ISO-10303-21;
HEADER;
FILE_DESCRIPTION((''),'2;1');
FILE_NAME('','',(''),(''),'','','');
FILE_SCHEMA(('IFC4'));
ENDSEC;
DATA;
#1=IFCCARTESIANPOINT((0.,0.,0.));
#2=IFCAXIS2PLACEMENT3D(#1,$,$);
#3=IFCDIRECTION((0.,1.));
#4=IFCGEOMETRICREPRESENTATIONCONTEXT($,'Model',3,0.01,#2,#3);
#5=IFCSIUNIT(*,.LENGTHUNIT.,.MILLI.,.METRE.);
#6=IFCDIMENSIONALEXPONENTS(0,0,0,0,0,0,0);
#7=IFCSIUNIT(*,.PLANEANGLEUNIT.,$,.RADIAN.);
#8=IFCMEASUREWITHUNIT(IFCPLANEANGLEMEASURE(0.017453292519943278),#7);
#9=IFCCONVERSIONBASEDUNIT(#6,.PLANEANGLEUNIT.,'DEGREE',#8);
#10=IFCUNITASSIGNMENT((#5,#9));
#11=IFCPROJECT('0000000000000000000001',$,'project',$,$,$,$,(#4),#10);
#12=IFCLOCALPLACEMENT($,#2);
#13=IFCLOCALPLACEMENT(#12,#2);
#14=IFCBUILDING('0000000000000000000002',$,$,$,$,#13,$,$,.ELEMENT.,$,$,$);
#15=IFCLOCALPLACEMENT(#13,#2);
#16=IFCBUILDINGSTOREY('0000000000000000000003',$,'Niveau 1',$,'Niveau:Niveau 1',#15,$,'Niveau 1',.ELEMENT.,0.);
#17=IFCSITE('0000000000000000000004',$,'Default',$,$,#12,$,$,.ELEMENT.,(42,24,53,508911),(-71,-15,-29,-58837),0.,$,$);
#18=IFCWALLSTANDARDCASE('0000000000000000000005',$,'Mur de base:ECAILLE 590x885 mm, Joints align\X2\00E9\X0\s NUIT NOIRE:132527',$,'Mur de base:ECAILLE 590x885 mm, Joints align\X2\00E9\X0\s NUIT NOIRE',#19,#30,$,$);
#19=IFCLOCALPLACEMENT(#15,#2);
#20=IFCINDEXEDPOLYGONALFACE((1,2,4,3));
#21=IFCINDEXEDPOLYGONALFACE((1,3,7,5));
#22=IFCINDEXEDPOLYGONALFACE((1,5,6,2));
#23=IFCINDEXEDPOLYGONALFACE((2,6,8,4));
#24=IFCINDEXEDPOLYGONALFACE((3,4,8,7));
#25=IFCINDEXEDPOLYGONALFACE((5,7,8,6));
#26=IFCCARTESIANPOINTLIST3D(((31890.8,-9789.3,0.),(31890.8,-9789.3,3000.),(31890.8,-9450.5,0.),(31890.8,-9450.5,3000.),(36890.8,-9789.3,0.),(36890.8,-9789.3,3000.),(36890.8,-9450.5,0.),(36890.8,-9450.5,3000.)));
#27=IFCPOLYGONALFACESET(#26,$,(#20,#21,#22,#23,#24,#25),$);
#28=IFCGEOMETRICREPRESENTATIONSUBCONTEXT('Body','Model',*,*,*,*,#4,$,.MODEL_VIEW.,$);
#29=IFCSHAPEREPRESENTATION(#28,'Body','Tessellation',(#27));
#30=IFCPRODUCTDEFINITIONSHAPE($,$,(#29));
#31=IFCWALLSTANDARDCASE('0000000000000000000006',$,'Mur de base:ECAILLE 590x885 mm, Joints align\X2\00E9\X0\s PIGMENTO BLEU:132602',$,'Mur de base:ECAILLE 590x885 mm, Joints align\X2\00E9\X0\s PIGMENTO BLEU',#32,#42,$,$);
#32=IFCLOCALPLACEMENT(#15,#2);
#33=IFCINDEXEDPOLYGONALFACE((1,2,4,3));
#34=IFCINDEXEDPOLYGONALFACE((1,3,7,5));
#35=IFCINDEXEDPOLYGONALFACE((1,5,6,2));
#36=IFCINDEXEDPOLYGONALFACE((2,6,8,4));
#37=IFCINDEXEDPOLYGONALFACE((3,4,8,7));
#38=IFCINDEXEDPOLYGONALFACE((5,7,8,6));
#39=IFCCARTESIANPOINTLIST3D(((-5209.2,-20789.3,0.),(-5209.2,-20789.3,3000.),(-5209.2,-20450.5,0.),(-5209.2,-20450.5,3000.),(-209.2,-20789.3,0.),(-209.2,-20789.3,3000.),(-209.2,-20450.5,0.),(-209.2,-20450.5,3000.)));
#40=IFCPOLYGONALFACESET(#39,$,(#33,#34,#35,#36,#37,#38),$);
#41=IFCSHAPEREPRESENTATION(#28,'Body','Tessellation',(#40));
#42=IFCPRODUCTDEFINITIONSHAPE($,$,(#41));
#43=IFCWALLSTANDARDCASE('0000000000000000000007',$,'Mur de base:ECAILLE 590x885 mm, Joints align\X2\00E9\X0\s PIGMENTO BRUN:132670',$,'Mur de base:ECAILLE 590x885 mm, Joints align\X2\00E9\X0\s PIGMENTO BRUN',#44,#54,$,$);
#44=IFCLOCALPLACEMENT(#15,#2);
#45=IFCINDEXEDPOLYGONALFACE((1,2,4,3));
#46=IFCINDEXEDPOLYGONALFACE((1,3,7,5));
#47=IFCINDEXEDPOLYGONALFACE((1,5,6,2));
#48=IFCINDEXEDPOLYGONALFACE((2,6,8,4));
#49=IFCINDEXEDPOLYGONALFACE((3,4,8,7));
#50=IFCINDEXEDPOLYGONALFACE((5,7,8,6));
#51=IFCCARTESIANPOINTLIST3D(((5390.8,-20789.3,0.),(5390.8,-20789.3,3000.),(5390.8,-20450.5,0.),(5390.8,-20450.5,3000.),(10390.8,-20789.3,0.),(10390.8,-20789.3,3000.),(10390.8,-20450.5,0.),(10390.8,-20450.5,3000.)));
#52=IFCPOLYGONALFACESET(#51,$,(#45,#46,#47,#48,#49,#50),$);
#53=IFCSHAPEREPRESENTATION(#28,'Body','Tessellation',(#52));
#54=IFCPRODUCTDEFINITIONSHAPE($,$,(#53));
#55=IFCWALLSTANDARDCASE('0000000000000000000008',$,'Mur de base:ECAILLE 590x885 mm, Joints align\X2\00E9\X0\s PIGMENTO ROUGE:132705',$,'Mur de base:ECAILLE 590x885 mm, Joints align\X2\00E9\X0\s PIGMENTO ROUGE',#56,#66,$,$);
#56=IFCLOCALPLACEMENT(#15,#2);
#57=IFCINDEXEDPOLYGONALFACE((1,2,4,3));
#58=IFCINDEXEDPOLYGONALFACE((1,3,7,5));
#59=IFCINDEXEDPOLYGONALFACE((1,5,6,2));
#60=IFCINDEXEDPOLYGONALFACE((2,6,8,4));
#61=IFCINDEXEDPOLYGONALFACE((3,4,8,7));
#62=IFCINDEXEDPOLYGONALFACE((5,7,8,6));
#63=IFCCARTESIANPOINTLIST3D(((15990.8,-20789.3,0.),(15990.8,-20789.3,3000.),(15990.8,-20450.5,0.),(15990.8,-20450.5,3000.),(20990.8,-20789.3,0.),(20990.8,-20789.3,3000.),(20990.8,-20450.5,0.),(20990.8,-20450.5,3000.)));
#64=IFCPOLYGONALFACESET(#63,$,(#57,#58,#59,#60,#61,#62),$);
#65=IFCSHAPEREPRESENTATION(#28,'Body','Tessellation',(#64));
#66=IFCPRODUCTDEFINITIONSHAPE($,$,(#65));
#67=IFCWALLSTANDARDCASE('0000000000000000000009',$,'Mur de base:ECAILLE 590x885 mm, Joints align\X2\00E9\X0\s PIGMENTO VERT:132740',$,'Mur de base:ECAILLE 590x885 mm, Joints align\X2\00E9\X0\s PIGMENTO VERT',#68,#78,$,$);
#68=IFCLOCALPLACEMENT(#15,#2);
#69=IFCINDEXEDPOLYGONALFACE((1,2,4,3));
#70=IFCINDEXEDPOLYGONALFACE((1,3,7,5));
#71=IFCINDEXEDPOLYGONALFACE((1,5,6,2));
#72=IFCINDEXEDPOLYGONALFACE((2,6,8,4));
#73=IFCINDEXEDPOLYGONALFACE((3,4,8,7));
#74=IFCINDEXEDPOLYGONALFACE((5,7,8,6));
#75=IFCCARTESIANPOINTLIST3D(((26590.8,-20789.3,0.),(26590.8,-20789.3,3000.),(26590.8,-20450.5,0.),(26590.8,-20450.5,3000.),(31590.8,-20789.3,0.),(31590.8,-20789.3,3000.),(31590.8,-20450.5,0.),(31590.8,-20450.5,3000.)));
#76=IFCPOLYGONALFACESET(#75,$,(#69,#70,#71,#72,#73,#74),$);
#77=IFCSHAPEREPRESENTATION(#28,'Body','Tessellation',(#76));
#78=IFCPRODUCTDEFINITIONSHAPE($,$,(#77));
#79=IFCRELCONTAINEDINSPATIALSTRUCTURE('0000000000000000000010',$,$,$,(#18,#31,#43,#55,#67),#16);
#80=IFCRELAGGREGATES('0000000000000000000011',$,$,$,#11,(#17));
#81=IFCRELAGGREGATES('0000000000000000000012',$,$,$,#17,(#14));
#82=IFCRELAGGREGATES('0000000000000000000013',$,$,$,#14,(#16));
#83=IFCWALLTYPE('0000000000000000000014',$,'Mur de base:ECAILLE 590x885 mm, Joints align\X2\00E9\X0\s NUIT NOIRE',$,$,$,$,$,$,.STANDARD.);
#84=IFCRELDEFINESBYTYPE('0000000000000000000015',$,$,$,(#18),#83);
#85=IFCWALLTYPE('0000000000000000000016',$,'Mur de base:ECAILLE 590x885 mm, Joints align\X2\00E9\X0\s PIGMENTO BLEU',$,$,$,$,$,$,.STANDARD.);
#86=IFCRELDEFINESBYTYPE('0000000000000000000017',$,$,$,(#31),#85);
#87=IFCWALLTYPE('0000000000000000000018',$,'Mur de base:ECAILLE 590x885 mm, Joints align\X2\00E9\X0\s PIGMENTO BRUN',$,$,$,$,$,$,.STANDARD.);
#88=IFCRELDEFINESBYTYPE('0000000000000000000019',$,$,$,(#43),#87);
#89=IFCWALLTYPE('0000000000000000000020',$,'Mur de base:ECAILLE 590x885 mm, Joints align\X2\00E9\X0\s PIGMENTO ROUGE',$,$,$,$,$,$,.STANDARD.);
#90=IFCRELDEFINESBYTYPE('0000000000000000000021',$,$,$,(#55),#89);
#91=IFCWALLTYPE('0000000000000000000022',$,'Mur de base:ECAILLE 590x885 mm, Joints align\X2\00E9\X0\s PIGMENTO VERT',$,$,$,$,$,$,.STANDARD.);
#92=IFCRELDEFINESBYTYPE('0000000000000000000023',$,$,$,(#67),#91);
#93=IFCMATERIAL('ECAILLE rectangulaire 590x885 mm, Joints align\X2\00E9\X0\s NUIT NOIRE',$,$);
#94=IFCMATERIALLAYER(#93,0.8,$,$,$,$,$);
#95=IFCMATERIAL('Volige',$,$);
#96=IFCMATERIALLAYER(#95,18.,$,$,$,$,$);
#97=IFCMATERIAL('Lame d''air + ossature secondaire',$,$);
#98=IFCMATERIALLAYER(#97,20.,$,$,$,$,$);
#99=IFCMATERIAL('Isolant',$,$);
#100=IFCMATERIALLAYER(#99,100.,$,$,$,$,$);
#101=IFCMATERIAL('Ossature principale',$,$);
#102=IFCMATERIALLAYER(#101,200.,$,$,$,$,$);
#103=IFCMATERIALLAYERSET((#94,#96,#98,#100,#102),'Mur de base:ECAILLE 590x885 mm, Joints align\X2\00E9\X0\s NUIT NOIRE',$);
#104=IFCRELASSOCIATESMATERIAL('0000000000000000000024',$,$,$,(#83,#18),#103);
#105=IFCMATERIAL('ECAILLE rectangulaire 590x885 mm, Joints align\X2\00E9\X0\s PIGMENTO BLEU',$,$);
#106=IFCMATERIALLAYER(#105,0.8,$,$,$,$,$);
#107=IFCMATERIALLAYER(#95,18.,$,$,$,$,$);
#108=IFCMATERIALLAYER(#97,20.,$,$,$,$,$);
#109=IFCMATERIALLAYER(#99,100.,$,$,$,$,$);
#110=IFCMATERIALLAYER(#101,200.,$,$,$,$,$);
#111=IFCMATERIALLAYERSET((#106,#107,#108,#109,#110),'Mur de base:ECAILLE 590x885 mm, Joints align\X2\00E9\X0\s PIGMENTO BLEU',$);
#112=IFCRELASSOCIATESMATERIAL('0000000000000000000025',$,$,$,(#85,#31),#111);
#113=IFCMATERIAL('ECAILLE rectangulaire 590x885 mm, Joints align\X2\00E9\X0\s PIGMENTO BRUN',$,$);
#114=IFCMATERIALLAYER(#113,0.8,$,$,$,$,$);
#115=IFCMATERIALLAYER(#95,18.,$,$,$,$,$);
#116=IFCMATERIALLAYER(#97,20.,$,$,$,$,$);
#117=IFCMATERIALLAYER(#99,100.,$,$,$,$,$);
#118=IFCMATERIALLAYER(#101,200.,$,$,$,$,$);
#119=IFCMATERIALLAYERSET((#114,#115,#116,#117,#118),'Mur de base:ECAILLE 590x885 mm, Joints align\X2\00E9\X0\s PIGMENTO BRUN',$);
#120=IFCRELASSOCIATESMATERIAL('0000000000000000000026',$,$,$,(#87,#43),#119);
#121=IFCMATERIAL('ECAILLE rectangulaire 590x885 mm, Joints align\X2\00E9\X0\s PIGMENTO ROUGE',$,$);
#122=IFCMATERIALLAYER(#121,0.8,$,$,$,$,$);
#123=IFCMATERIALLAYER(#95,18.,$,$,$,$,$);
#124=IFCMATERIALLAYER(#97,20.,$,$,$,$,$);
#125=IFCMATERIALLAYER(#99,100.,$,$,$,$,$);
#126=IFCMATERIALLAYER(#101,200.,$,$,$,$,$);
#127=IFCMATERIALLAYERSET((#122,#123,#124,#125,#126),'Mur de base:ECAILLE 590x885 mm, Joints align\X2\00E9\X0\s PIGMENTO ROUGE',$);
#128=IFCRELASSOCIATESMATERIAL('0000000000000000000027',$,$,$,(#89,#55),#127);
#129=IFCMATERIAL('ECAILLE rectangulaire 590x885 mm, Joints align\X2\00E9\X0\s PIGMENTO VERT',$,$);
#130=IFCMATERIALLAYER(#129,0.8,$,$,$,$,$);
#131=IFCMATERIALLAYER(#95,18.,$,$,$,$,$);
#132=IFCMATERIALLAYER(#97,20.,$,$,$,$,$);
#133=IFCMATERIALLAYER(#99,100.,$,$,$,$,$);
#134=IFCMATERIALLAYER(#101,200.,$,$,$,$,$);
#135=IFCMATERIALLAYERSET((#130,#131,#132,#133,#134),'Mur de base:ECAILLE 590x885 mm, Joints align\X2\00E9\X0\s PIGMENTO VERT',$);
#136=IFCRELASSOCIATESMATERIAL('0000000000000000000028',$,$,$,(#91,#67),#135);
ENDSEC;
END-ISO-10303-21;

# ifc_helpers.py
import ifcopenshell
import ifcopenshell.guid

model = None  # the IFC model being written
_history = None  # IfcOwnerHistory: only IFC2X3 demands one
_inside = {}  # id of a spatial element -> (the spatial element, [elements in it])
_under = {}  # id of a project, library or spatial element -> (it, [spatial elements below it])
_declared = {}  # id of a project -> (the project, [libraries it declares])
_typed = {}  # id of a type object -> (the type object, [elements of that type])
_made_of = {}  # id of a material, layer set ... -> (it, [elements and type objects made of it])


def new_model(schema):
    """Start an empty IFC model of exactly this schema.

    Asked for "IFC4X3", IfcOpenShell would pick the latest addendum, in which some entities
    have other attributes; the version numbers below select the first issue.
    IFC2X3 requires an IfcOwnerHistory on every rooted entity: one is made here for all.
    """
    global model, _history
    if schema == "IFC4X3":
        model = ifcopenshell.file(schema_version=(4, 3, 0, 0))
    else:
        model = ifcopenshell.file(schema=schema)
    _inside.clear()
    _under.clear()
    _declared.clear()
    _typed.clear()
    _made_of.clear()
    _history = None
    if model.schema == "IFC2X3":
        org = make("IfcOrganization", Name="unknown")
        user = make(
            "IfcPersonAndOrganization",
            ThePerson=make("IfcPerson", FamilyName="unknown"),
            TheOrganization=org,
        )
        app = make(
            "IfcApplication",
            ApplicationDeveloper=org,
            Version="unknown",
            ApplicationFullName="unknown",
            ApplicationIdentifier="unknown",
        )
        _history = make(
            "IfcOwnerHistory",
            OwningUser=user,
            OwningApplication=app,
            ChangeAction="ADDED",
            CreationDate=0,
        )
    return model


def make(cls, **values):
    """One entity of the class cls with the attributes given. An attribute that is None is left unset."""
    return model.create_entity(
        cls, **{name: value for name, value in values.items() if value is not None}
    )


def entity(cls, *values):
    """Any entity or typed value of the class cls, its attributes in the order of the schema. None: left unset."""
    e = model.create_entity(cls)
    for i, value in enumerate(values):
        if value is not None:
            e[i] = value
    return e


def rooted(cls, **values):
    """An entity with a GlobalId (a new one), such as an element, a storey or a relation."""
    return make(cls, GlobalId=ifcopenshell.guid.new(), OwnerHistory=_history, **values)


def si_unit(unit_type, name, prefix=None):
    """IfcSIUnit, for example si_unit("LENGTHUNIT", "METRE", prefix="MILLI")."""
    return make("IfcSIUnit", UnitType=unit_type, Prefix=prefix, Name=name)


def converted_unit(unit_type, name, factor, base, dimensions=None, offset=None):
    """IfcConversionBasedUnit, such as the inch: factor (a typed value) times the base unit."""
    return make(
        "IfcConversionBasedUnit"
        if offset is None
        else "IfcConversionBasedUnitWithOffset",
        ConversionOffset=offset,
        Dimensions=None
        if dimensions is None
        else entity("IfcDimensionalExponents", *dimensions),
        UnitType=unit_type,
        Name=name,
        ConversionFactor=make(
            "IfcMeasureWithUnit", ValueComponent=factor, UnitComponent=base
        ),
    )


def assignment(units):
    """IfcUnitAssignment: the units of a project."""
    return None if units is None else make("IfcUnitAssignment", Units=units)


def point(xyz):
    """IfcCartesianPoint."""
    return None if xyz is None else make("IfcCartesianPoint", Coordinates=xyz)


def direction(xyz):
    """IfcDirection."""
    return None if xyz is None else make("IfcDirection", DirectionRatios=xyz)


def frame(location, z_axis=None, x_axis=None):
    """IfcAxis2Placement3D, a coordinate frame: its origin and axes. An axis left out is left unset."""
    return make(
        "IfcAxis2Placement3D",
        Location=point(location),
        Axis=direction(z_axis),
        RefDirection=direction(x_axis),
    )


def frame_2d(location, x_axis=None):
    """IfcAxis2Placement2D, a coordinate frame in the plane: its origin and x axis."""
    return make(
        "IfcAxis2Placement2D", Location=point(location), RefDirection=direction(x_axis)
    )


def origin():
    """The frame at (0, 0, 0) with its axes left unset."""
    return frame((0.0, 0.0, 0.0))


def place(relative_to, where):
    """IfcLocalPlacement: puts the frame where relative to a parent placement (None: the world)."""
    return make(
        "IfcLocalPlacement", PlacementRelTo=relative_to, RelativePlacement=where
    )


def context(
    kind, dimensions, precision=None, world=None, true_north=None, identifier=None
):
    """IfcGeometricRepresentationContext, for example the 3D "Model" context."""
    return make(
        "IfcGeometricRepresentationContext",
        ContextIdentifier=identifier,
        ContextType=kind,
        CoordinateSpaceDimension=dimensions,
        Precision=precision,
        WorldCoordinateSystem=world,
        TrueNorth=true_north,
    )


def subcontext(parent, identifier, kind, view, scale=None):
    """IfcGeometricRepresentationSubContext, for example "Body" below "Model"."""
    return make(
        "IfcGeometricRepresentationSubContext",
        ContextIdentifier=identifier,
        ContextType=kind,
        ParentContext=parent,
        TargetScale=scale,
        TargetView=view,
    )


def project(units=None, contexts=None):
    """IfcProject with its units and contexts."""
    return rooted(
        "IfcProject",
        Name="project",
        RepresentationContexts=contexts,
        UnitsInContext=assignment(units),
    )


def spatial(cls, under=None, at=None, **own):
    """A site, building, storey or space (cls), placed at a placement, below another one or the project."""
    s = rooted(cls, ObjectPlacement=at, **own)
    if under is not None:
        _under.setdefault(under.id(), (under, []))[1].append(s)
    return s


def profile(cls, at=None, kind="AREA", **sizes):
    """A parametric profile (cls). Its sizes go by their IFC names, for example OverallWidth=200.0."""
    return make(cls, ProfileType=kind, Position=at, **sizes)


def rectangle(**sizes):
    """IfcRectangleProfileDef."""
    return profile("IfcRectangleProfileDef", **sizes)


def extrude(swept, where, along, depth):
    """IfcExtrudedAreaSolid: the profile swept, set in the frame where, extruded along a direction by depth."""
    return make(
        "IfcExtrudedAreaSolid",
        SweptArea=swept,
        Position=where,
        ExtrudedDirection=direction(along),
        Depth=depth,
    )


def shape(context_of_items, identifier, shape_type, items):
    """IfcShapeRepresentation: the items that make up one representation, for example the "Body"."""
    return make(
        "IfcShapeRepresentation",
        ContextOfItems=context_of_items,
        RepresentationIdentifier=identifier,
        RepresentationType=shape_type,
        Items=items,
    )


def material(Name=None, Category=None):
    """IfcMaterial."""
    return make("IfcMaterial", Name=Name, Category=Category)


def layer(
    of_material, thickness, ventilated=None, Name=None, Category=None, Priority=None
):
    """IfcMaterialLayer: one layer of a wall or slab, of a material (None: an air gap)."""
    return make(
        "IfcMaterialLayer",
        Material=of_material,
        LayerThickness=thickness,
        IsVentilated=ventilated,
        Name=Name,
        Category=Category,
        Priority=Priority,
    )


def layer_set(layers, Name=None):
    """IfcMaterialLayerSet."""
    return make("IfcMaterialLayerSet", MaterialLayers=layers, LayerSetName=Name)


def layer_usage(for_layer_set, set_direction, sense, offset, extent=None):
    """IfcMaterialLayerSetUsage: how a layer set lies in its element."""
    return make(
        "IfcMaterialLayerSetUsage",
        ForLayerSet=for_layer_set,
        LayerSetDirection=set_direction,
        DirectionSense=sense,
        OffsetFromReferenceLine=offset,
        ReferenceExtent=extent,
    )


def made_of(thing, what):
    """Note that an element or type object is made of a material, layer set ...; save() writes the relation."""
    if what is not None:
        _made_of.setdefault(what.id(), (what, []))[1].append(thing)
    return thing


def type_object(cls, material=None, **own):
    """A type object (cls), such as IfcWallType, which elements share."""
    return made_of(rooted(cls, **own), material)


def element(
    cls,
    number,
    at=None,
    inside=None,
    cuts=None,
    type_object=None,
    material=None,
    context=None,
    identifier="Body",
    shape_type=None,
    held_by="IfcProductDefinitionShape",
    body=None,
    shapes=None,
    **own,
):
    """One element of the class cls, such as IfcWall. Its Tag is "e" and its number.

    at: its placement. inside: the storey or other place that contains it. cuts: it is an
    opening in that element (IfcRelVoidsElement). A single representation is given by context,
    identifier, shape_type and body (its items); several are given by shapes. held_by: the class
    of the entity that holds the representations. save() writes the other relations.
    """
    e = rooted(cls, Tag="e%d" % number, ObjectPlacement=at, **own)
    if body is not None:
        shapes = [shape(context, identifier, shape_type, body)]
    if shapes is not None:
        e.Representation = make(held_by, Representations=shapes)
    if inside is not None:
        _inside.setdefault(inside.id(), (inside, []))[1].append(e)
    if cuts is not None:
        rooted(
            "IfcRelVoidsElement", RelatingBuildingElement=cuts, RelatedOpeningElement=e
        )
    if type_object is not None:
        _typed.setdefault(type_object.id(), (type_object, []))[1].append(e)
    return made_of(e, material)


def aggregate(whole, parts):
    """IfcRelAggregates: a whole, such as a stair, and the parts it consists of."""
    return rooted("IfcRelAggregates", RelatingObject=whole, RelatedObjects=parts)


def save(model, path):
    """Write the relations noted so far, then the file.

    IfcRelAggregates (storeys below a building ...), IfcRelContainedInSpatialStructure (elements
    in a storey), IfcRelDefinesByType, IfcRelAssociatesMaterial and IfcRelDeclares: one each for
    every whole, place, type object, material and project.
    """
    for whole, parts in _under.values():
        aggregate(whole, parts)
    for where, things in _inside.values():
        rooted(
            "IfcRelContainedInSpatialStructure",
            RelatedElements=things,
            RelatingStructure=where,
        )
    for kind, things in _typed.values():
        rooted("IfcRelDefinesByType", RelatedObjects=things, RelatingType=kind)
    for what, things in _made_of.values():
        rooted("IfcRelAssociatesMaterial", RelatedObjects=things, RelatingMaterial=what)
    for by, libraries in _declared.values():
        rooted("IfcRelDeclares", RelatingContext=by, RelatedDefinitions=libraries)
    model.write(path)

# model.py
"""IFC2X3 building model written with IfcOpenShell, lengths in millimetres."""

from ifc_helpers import new_model, entity, si_unit, converted_unit, direction, frame, frame_2d, origin, place, context, subcontext, project, spatial, rectangle, extrude, material, layer, layer_set, layer_usage, type_object, element, save


model = new_model("IFC2X3")

# Units and contexts
model_context = context("Model", 3, precision=0.01, world=origin(), true_north=direction((0.0, 1.0)))
body_context = subcontext(model_context, "Body", "Model", "MODEL_VIEW")
ifc_project = project(units=[si_unit("LENGTHUNIT", "METRE", prefix="MILLI"), converted_unit("PLANEANGLEUNIT", "DEGREE", entity("IfcPlaneAngleMeasure", 0.017453292519943278), si_unit("PLANEANGLEUNIT", "RADIAN"), dimensions=[0, 0, 0, 0, 0, 0, 0])], contexts=[model_context])

# Site, building, storey
site_placement = place(None, origin())
site = spatial("IfcSite", under=ifc_project, at=site_placement, Name="Default", CompositionType="ELEMENT", RefLatitude=(42, 24, 53, 508911), RefLongitude=(-71, -15, -29, -58837), RefElevation=0.0)
building_placement = place(site_placement, origin())
building = spatial("IfcBuilding", under=site, at=building_placement, CompositionType="ELEMENT")
storey_placement = place(building_placement, origin())
storey = spatial("IfcBuildingStorey", under=building, at=storey_placement, Name="Niveau 1", ObjectType="Niveau:Niveau 1", LongName="Niveau 1", CompositionType="ELEMENT", Elevation=0.0)

# Walls
ifc_material_1 = material(Name="Volige")
ifc_material_2 = material(Name="Lame d'air + ossature secondaire")
ifc_material_3 = material(Name="Isolant")
ifc_material_4 = material(Name="Ossature principale")
ifc_material_5 = material(Name="ECAILLE rectangulaire 590x885 mm, Joints alignés NUIT NOIRE")
ifc_layer_1 = layer(ifc_material_5, 0.8)
ifc_layer_2 = layer(ifc_material_1, 18.0)
ifc_layer_3 = layer(ifc_material_2, 20.0)
ifc_layer_4 = layer(ifc_material_3, 100.0)
ifc_layer_5 = layer(ifc_material_4, 200.0)
ifc_layer_set_1 = layer_set([ifc_layer_1, ifc_layer_2, ifc_layer_3, ifc_layer_4, ifc_layer_5], Name="Mur de base:ECAILLE 590x885 mm, Joints alignés NUIT NOIRE")
ifc_layer_usage_1 = layer_usage(ifc_layer_set_1, "AXIS2", "NEGATIVE", 169.4)
wall_type_1 = type_object("IfcWallType", Name="Mur de base:ECAILLE 590x885 mm, Joints alignés NUIT NOIRE", PredefinedType="STANDARD", material=ifc_layer_set_1)
wall_1_placement = place(storey_placement, frame((36890.8, -9619.9, 0.0), z_axis=(0.0, 0.0, 1.0), x_axis=(-1.0, 0.0, 0.0)))
element("IfcWallStandardCase", 1, at=wall_1_placement, inside=storey, type_object=wall_type_1, material=ifc_layer_usage_1, Name="Mur de base:ECAILLE 590x885 mm, Joints alignés NUIT NOIRE:132527", ObjectType="Mur de base:ECAILLE 590x885 mm, Joints alignés NUIT NOIRE", context=body_context, shape_type="SweptSolid", body=[
    extrude(rectangle(XDim=5000.0, YDim=338.8, at=frame_2d((2500.0, 0.0), x_axis=(-1.0, 0.0))), origin(), (0.0, 0.0, 1.0), 3000.0),
])
ifc_material_6 = material(Name="ECAILLE rectangulaire 590x885 mm, Joints alignés PIGMENTO BLEU")
ifc_layer_6 = layer(ifc_material_6, 0.8)
ifc_layer_7 = layer(ifc_material_1, 18.0)
ifc_layer_8 = layer(ifc_material_2, 20.0)
ifc_layer_9 = layer(ifc_material_3, 100.0)
ifc_layer_10 = layer(ifc_material_4, 200.0)
ifc_layer_set_2 = layer_set([ifc_layer_6, ifc_layer_7, ifc_layer_8, ifc_layer_9, ifc_layer_10], Name="Mur de base:ECAILLE 590x885 mm, Joints alignés PIGMENTO BLEU")
ifc_layer_usage_2 = layer_usage(ifc_layer_set_2, "AXIS2", "NEGATIVE", 169.4)
wall_type_2 = type_object("IfcWallType", Name="Mur de base:ECAILLE 590x885 mm, Joints alignés PIGMENTO BLEU", PredefinedType="STANDARD", material=ifc_layer_set_2)
wall_2_placement = place(storey_placement, frame((-209.2, -20619.9, 0.0), z_axis=(0.0, 0.0, 1.0), x_axis=(-1.0, 0.0, 0.0)))
element("IfcWallStandardCase", 2, at=wall_2_placement, inside=storey, type_object=wall_type_2, material=ifc_layer_usage_2, Name="Mur de base:ECAILLE 590x885 mm, Joints alignés PIGMENTO BLEU:132602", ObjectType="Mur de base:ECAILLE 590x885 mm, Joints alignés PIGMENTO BLEU", context=body_context, shape_type="SweptSolid", body=[
    extrude(rectangle(XDim=5000.0, YDim=338.8, at=frame_2d((2500.0, 0.0), x_axis=(-1.0, 0.0))), origin(), (0.0, 0.0, 1.0), 3000.0),
])
ifc_material_7 = material(Name="ECAILLE rectangulaire 590x885 mm, Joints alignés PIGMENTO BRUN")
ifc_layer_11 = layer(ifc_material_7, 0.8)
ifc_layer_12 = layer(ifc_material_1, 18.0)
ifc_layer_13 = layer(ifc_material_2, 20.0)
ifc_layer_14 = layer(ifc_material_3, 100.0)
ifc_layer_15 = layer(ifc_material_4, 200.0)
ifc_layer_set_3 = layer_set([ifc_layer_11, ifc_layer_12, ifc_layer_13, ifc_layer_14, ifc_layer_15], Name="Mur de base:ECAILLE 590x885 mm, Joints alignés PIGMENTO BRUN")
ifc_layer_usage_3 = layer_usage(ifc_layer_set_3, "AXIS2", "NEGATIVE", 169.4)
wall_type_3 = type_object("IfcWallType", Name="Mur de base:ECAILLE 590x885 mm, Joints alignés PIGMENTO BRUN", PredefinedType="STANDARD", material=ifc_layer_set_3)
wall_3_placement = place(storey_placement, frame((10390.8, -20619.9, 0.0), z_axis=(0.0, 0.0, 1.0), x_axis=(-1.0, 0.0, 0.0)))
element("IfcWallStandardCase", 3, at=wall_3_placement, inside=storey, type_object=wall_type_3, material=ifc_layer_usage_3, Name="Mur de base:ECAILLE 590x885 mm, Joints alignés PIGMENTO BRUN:132670", ObjectType="Mur de base:ECAILLE 590x885 mm, Joints alignés PIGMENTO BRUN", context=body_context, shape_type="SweptSolid", body=[
    extrude(rectangle(XDim=5000.0, YDim=338.8, at=frame_2d((2500.0, 0.0), x_axis=(-1.0, 0.0))), origin(), (0.0, 0.0, 1.0), 3000.0),
])
ifc_material_8 = material(Name="ECAILLE rectangulaire 590x885 mm, Joints alignés PIGMENTO ROUGE")
ifc_layer_16 = layer(ifc_material_8, 0.8)
ifc_layer_17 = layer(ifc_material_1, 18.0)
ifc_layer_18 = layer(ifc_material_2, 20.0)
ifc_layer_19 = layer(ifc_material_3, 100.0)
ifc_layer_20 = layer(ifc_material_4, 200.0)
ifc_layer_set_4 = layer_set([ifc_layer_16, ifc_layer_17, ifc_layer_18, ifc_layer_19, ifc_layer_20], Name="Mur de base:ECAILLE 590x885 mm, Joints alignés PIGMENTO ROUGE")
ifc_layer_usage_4 = layer_usage(ifc_layer_set_4, "AXIS2", "NEGATIVE", 169.4)
wall_type_4 = type_object("IfcWallType", Name="Mur de base:ECAILLE 590x885 mm, Joints alignés PIGMENTO ROUGE", PredefinedType="STANDARD", material=ifc_layer_set_4)
wall_4_placement = place(storey_placement, frame((20990.8, -20619.9, 0.0), z_axis=(0.0, 0.0, 1.0), x_axis=(-1.0, 0.0, 0.0)))
element("IfcWallStandardCase", 4, at=wall_4_placement, inside=storey, type_object=wall_type_4, material=ifc_layer_usage_4, Name="Mur de base:ECAILLE 590x885 mm, Joints alignés PIGMENTO ROUGE:132705", ObjectType="Mur de base:ECAILLE 590x885 mm, Joints alignés PIGMENTO ROUGE", context=body_context, shape_type="SweptSolid", body=[
    extrude(rectangle(XDim=5000.0, YDim=338.8, at=frame_2d((2500.0, 0.0), x_axis=(-1.0, 0.0))), origin(), (0.0, 0.0, 1.0), 3000.0),
])
ifc_material_9 = material(Name="ECAILLE rectangulaire 590x885 mm, Joints alignés PIGMENTO VERT")
ifc_layer_21 = layer(ifc_material_9, 0.8)
ifc_layer_22 = layer(ifc_material_1, 18.0)
ifc_layer_23 = layer(ifc_material_2, 20.0)
ifc_layer_24 = layer(ifc_material_3, 100.0)
ifc_layer_25 = layer(ifc_material_4, 200.0)
ifc_layer_set_5 = layer_set([ifc_layer_21, ifc_layer_22, ifc_layer_23, ifc_layer_24, ifc_layer_25], Name="Mur de base:ECAILLE 590x885 mm, Joints alignés PIGMENTO VERT")
ifc_layer_usage_5 = layer_usage(ifc_layer_set_5, "AXIS2", "NEGATIVE", 169.4)
wall_type_5 = type_object("IfcWallType", Name="Mur de base:ECAILLE 590x885 mm, Joints alignés PIGMENTO VERT", PredefinedType="STANDARD", material=ifc_layer_set_5)
wall_5_placement = place(storey_placement, frame((31590.8, -20619.9, 0.0), z_axis=(0.0, 0.0, 1.0), x_axis=(-1.0, 0.0, 0.0)))
element("IfcWallStandardCase", 5, at=wall_5_placement, inside=storey, type_object=wall_type_5, material=ifc_layer_usage_5, Name="Mur de base:ECAILLE 590x885 mm, Joints alignés PIGMENTO VERT:132740", ObjectType="Mur de base:ECAILLE 590x885 mm, Joints alignés PIGMENTO VERT", context=body_context, shape_type="SweptSolid", body=[
    extrude(rectangle(XDim=5000.0, YDim=338.8, at=frame_2d((2500.0, 0.0), x_axis=(-1.0, 0.0))), origin(), (0.0, 0.0, 1.0), 3000.0),
])

save(model, "model.ifc")
